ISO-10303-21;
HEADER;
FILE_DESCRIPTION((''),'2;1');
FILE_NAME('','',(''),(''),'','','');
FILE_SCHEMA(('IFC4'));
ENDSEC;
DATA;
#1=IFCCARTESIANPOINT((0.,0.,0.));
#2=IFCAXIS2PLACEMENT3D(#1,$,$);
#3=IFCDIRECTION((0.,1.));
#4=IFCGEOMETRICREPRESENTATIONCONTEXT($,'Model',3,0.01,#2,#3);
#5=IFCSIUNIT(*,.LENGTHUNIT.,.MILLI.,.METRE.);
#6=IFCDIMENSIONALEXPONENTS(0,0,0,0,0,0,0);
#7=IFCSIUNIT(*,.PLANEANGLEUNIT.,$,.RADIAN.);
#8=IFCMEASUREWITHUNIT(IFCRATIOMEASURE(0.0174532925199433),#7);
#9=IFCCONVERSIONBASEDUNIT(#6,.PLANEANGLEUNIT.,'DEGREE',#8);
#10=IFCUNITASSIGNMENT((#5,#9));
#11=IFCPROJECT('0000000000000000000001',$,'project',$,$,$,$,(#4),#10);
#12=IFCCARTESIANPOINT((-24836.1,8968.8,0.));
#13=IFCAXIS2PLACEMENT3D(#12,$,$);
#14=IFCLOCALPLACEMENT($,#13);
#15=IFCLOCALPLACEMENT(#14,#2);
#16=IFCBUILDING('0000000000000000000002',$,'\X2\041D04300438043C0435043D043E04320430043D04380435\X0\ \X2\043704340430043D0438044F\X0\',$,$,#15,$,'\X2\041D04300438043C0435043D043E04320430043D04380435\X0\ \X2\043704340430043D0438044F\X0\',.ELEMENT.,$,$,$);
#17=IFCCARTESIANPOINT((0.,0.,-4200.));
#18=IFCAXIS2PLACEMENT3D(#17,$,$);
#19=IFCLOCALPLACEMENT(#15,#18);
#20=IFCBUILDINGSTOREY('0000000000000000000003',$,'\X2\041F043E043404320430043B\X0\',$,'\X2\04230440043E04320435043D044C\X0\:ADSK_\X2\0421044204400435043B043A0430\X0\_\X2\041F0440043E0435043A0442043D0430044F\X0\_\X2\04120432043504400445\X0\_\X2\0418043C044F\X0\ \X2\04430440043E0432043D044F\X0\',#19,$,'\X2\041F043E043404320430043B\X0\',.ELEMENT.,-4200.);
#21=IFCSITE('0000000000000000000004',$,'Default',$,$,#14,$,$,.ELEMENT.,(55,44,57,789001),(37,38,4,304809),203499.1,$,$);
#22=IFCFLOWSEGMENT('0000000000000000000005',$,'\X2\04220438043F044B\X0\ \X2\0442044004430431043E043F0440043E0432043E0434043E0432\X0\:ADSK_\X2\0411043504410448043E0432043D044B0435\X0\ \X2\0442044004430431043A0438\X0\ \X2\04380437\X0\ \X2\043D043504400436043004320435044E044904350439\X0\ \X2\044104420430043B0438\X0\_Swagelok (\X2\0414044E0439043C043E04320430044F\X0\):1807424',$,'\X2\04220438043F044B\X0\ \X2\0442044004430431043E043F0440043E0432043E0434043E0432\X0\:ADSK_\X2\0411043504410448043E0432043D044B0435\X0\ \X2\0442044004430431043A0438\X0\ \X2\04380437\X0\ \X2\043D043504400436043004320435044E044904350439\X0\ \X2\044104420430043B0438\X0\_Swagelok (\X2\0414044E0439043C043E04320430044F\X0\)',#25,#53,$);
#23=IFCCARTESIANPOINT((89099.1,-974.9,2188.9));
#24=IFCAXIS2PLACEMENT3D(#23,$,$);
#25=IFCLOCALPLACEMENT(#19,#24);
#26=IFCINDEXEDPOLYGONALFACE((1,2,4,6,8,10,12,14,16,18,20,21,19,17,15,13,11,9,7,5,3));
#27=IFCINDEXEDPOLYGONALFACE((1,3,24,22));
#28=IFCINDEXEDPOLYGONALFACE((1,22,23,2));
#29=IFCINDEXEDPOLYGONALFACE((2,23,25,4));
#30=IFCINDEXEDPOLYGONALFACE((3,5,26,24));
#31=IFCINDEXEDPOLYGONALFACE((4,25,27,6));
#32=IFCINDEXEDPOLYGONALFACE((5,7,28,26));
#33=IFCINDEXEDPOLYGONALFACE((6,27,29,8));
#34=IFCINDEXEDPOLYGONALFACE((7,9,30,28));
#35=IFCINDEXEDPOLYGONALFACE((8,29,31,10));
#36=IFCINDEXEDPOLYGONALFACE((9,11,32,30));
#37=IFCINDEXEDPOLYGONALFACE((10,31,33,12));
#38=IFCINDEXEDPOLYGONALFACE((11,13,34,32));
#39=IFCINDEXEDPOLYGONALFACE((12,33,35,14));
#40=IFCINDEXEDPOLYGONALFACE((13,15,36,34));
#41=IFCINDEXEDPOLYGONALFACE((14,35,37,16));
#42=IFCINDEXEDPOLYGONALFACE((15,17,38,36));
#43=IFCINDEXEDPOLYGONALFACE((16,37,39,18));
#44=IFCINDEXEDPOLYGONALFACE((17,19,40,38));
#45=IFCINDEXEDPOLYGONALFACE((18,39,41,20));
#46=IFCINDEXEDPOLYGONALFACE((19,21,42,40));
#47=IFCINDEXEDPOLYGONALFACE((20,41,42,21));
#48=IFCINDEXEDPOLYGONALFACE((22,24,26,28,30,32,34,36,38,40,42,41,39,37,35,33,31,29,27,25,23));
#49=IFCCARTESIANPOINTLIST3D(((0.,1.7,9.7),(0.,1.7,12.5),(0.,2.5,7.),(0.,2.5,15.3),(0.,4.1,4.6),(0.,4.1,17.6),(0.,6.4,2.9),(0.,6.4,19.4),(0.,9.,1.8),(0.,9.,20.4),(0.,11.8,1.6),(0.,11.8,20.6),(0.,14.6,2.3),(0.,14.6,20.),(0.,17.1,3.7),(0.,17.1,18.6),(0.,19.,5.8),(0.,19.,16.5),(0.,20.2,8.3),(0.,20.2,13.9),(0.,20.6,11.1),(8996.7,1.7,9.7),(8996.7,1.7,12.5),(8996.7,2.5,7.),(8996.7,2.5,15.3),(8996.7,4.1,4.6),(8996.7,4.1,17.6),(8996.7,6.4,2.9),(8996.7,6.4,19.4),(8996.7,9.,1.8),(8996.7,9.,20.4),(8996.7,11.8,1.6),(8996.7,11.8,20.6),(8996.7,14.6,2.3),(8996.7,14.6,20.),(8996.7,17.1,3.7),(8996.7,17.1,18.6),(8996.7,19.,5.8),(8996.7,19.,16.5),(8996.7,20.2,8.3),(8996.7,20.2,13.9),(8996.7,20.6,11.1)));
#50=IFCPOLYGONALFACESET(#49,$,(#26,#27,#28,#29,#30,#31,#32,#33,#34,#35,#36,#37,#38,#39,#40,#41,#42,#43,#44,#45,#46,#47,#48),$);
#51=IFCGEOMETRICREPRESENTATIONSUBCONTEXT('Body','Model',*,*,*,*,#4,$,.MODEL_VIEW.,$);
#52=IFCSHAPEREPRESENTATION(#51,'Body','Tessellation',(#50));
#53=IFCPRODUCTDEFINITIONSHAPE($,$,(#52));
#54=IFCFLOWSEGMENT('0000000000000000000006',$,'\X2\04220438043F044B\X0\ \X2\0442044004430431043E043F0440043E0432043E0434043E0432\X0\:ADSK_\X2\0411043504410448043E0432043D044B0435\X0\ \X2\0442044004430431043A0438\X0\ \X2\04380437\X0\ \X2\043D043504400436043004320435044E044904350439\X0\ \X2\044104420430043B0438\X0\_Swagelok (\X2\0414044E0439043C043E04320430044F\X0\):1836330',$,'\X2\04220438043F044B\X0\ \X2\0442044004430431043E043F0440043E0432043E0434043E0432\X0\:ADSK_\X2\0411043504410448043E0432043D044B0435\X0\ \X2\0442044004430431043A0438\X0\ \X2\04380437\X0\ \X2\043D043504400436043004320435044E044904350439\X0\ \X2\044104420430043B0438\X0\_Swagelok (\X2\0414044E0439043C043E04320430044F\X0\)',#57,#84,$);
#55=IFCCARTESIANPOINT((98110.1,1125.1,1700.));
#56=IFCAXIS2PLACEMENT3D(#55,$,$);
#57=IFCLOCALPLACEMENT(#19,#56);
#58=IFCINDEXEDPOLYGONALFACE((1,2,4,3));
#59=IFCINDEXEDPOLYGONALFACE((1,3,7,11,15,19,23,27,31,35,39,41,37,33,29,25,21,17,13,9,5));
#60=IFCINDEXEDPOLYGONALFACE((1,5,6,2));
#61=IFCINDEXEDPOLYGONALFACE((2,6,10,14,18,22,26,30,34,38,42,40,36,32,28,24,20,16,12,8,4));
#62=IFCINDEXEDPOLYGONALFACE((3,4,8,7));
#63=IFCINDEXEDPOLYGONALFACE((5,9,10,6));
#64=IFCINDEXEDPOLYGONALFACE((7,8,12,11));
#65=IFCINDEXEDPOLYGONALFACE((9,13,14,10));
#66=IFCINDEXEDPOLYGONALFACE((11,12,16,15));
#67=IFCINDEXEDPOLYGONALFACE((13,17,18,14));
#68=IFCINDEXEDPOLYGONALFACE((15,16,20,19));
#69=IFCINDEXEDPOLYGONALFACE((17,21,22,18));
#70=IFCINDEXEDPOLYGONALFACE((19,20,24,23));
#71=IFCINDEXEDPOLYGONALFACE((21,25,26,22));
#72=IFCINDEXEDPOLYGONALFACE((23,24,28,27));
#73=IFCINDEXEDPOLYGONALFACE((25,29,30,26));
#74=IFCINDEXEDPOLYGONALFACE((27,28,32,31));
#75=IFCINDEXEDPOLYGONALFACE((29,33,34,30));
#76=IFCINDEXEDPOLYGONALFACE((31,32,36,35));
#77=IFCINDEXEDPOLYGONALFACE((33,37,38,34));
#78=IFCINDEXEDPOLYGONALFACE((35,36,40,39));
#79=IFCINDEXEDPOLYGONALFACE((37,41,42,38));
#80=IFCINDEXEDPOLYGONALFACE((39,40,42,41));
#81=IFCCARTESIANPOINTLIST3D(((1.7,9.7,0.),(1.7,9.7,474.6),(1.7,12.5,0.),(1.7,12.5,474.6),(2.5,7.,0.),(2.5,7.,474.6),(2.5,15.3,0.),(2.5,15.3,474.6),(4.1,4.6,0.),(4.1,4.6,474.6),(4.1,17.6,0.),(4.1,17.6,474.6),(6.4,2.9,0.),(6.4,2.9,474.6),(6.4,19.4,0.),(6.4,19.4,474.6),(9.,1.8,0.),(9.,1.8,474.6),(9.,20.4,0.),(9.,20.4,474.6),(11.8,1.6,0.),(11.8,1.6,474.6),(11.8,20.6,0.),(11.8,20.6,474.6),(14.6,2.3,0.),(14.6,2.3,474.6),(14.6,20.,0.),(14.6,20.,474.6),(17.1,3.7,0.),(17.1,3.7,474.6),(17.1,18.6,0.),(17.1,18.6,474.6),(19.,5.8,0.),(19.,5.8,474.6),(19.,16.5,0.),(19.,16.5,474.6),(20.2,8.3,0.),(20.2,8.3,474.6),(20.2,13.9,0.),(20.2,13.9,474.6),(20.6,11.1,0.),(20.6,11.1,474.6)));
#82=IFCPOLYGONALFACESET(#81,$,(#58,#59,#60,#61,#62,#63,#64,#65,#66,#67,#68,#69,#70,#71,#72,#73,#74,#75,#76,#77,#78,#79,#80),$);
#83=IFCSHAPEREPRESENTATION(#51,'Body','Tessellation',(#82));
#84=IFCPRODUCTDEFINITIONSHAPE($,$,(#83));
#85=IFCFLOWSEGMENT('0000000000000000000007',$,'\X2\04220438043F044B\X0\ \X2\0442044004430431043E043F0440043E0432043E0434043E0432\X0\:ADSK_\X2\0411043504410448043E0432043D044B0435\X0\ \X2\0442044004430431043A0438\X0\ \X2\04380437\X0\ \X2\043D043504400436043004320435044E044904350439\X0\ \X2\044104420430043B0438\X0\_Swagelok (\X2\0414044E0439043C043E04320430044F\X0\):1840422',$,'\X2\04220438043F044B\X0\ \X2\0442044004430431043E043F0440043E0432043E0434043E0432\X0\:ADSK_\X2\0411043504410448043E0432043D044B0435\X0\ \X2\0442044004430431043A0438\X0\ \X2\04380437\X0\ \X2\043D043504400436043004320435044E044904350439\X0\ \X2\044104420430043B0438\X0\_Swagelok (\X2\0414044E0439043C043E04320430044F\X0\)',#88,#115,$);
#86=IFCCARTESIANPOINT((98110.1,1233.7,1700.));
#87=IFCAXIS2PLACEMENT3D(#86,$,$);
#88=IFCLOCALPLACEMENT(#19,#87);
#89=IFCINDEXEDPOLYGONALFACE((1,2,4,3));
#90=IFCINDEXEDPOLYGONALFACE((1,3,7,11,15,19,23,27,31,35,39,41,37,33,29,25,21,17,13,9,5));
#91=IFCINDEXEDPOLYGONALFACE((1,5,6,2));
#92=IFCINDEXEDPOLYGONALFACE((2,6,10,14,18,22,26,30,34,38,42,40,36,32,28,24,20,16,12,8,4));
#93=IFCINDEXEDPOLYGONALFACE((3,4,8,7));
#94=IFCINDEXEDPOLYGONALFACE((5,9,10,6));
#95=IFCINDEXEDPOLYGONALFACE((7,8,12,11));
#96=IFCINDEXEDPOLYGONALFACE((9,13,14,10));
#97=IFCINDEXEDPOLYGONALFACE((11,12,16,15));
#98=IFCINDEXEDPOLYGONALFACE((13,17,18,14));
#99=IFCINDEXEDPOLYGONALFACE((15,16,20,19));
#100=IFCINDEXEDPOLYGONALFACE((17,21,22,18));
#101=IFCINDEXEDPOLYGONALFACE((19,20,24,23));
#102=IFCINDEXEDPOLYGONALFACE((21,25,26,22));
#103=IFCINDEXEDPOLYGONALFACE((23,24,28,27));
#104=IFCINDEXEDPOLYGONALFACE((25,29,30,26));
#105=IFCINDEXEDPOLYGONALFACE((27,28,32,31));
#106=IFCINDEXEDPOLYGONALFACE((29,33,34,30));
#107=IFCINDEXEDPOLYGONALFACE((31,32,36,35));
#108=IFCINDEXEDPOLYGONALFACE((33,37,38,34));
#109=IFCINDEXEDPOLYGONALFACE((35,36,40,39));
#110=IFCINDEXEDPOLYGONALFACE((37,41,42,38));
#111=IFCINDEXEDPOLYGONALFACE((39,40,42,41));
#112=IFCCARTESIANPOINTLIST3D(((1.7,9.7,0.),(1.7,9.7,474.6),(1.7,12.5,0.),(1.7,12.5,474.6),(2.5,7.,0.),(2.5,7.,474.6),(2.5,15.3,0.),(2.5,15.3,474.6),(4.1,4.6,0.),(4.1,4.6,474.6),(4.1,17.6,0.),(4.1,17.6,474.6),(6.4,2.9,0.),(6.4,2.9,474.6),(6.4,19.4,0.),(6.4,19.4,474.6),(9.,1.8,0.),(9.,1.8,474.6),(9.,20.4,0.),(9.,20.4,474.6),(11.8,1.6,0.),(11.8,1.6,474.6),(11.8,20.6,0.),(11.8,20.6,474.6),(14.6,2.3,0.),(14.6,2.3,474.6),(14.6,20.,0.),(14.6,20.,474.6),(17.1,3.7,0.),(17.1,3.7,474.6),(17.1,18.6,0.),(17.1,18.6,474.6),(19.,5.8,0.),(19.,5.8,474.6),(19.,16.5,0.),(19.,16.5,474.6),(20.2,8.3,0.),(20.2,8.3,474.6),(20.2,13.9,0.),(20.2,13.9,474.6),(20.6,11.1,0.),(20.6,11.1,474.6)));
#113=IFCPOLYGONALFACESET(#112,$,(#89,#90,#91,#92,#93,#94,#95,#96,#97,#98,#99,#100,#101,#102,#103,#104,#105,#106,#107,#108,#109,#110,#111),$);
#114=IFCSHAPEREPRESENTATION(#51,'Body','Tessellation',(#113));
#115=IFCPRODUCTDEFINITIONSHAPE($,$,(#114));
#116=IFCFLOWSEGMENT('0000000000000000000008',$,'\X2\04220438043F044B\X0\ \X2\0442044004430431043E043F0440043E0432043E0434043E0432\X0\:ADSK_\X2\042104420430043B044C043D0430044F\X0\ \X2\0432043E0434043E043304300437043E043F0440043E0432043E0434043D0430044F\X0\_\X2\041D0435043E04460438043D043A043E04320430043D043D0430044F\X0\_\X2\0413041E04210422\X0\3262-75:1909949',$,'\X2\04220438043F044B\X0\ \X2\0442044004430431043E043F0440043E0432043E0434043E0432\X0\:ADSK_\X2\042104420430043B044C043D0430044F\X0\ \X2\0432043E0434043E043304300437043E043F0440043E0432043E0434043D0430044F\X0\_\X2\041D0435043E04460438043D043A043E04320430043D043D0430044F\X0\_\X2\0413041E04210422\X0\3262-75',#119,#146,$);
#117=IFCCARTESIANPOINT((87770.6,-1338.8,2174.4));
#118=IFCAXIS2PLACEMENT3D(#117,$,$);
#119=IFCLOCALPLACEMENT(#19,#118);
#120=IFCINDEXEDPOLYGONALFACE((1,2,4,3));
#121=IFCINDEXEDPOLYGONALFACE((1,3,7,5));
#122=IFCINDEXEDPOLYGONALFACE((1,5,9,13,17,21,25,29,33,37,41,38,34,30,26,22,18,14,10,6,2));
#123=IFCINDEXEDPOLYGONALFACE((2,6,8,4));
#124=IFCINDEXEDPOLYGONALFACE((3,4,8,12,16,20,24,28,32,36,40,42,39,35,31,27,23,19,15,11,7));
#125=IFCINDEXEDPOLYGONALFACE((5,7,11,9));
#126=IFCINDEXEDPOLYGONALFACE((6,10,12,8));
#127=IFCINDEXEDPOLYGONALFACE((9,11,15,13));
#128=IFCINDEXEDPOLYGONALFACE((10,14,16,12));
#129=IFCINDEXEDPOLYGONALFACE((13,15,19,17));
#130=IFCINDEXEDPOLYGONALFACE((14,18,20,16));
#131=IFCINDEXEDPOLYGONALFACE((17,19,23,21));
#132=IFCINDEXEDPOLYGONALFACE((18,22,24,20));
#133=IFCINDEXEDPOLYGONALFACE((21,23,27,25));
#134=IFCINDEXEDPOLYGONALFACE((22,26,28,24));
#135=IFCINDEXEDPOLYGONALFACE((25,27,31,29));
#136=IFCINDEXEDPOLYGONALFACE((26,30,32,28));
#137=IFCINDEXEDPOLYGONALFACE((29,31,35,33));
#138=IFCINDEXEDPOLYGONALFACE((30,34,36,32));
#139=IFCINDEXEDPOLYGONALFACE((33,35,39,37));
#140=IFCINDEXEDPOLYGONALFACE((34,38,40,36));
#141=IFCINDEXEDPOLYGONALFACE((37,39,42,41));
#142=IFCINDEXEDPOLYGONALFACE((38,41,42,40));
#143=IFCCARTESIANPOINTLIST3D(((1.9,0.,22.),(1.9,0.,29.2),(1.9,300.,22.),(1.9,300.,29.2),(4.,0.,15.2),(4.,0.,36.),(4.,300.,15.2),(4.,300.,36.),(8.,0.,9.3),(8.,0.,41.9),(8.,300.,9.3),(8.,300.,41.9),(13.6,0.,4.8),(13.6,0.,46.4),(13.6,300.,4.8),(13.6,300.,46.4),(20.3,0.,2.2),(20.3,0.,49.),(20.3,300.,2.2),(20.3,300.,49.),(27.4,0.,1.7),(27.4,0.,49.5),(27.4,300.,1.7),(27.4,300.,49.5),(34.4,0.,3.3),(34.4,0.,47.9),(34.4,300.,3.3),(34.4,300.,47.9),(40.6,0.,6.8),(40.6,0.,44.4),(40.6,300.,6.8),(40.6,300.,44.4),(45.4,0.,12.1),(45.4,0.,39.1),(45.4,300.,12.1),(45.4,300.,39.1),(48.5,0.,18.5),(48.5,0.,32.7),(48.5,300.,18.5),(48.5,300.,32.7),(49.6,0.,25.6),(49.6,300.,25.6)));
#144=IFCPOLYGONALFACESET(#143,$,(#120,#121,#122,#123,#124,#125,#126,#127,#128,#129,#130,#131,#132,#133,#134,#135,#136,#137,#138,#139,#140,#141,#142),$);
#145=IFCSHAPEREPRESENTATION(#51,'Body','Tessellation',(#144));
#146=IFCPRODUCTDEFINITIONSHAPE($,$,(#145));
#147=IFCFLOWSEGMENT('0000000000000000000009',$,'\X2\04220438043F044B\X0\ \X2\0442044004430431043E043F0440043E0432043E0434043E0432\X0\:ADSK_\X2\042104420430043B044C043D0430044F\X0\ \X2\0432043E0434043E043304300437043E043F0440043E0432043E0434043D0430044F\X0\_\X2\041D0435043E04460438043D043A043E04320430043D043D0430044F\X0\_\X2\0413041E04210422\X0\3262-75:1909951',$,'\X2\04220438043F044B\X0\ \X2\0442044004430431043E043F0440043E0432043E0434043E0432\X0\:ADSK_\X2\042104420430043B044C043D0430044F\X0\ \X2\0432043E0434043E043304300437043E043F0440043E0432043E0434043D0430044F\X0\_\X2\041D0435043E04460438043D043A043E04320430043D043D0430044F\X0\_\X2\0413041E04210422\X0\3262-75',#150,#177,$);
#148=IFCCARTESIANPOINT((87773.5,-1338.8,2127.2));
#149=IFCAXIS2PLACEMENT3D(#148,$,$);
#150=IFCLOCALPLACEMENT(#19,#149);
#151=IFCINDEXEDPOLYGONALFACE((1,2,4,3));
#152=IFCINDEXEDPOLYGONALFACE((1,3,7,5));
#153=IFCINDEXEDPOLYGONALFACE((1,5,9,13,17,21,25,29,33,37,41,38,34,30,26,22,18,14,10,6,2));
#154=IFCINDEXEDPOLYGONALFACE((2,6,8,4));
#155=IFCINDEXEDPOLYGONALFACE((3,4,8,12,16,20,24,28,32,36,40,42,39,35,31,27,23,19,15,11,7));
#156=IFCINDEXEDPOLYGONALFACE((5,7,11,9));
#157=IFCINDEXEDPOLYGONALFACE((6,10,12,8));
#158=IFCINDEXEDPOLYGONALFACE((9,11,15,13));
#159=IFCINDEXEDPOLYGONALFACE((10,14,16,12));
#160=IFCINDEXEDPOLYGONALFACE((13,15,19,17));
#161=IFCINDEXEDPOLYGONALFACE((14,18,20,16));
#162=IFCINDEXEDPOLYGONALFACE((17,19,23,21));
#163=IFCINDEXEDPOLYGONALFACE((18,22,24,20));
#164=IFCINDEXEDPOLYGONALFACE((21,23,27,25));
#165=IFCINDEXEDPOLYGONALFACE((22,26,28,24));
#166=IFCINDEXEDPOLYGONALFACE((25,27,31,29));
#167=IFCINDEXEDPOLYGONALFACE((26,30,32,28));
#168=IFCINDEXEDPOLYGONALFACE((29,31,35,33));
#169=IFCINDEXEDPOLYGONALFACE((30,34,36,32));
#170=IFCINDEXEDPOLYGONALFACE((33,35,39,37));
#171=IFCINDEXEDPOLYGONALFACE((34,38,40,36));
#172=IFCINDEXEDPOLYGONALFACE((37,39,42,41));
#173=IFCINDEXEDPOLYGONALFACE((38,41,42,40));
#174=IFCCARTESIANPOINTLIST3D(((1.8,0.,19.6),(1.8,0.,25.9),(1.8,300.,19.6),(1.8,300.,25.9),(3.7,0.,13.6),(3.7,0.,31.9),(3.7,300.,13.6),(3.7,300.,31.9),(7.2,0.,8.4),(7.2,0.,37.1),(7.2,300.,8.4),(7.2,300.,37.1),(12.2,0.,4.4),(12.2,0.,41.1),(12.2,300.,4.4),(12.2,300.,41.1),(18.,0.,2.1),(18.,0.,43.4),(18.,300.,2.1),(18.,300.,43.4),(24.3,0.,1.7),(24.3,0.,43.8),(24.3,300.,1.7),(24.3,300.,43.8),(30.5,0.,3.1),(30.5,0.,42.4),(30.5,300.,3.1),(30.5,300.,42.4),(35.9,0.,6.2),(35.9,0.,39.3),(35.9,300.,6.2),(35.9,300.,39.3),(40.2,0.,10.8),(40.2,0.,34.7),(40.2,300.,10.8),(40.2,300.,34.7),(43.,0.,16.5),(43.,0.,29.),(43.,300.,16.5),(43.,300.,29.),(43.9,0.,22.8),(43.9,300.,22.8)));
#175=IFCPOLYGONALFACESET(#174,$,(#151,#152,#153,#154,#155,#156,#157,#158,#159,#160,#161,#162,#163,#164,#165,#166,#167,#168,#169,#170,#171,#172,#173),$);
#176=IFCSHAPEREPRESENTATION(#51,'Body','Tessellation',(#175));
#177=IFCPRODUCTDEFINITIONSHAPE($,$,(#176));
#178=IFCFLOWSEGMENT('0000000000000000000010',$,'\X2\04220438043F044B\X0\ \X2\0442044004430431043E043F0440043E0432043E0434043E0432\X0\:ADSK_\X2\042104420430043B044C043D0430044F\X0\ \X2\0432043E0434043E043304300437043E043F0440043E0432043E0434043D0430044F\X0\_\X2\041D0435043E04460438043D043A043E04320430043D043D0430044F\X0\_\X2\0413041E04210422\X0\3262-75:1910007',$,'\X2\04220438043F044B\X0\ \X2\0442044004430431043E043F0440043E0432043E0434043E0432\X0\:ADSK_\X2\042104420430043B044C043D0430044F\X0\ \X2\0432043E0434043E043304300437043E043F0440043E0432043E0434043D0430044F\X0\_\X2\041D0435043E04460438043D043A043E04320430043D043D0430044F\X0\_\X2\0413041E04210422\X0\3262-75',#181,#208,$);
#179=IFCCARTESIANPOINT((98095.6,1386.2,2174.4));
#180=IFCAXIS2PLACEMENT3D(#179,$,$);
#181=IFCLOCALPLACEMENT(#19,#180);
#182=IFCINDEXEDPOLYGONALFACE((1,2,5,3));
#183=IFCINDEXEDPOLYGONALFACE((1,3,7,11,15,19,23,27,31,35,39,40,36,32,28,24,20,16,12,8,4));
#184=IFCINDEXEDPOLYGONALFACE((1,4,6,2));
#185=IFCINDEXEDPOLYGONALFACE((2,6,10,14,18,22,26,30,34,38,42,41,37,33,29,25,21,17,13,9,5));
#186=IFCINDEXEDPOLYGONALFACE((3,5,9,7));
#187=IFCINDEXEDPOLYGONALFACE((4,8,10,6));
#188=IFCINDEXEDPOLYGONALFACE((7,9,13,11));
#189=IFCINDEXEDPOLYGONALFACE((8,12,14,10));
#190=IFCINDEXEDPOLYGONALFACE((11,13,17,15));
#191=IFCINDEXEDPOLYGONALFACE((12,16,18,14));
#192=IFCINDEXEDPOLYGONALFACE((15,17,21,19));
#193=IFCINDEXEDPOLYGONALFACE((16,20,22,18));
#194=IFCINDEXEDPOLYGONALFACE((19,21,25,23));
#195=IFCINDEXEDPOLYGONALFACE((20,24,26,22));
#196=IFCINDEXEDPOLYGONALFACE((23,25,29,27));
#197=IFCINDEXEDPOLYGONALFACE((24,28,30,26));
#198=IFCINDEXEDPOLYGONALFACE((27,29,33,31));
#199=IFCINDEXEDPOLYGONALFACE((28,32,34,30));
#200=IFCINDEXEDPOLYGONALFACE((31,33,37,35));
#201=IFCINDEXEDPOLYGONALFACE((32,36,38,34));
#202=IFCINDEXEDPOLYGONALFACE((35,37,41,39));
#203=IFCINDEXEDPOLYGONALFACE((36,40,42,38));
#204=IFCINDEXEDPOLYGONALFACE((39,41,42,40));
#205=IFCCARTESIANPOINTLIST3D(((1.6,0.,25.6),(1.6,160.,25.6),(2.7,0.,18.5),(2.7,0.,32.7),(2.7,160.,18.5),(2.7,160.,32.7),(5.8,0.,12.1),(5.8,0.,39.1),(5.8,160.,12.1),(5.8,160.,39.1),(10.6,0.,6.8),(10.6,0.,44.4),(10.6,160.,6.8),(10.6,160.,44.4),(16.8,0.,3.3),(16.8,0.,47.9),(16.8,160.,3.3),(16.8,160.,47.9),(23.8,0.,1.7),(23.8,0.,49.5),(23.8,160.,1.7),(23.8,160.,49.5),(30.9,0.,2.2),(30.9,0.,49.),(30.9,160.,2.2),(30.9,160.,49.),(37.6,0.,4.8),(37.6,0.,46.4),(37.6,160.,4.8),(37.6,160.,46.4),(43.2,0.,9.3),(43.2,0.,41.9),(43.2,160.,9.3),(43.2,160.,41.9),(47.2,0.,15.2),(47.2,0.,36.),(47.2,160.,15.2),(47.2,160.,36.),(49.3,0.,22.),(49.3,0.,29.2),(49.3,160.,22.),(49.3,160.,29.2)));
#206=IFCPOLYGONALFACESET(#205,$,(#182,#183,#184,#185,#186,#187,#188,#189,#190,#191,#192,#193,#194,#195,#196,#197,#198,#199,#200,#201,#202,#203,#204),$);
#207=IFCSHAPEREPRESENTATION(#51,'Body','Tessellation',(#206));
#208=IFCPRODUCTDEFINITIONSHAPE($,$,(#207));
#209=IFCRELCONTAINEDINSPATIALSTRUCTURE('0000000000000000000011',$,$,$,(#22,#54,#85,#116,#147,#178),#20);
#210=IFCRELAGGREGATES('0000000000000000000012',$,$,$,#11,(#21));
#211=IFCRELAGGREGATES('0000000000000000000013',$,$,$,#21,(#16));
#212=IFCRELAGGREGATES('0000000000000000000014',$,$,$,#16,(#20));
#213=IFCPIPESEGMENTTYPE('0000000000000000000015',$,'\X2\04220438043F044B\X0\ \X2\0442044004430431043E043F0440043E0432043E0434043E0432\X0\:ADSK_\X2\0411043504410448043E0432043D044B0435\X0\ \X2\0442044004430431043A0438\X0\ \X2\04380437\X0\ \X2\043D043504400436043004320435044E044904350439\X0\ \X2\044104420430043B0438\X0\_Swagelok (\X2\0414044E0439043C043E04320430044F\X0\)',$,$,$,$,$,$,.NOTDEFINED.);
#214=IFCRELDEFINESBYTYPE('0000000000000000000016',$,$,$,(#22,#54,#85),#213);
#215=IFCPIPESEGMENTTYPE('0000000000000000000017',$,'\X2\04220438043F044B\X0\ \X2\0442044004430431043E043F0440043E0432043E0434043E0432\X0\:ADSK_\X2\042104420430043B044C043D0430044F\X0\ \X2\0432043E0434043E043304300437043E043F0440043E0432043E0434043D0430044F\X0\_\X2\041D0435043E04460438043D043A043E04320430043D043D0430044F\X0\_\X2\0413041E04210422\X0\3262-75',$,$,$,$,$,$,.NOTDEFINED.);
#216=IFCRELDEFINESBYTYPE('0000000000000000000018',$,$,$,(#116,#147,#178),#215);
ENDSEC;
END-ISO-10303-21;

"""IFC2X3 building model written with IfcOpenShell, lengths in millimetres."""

from ifc_helpers import new_model, entity, si_unit, converted_unit, direction, frame, origin, origin_2d_with_axis, place, context, subcontext, project, spatial, circle, extrude, type_object, element, save


model = new_model("IFC2X3")

# Units and contexts
model_context = context("Model", 3, precision=0.01, world=origin(), true_north=direction((0.0, 1.0)))
body_context = subcontext(model_context, "Body", "Model", "MODEL_VIEW")
ifc_project = project(units=[si_unit("LENGTHUNIT", "METRE", prefix="MILLI"), converted_unit("PLANEANGLEUNIT", "DEGREE", entity("IfcRatioMeasure", 0.0174532925199433), si_unit("PLANEANGLEUNIT", "RADIAN"), dimensions=[0, 0, 0, 0, 0, 0, 0])], contexts=[model_context])

# Site, building, storey
site_placement = place(None, frame((-24836.1, 8968.8, 0.0)))
site = spatial("IfcSite", under=ifc_project, at=site_placement, Name="Default", CompositionType="ELEMENT", RefLatitude=(55, 44, 57, 789001), RefLongitude=(37, 38, 4, 304809), RefElevation=203499.1)
building_placement = place(site_placement, origin())
building = spatial("IfcBuilding", under=site, at=building_placement, Name="Наименование здания", LongName="Наименование здания", CompositionType="ELEMENT")
storey_placement = place(building_placement, frame((0.0, 0.0, -4200.0)))
storey = spatial("IfcBuildingStorey", under=building, at=storey_placement, Name="Подвал", ObjectType="Уровень:ADSK_Стрелка_Проектная_Вверх_Имя уровня", LongName="Подвал", CompositionType="ELEMENT", Elevation=-4200.0)

# Flow segments
pipe_segment_type_1 = type_object("IfcPipeSegmentType", Name="Типы трубопроводов:ADSK_Бесшовные трубки из нержавеющей стали_Swagelok (Дюймовая)", PredefinedType="NOTDEFINED")
flow_segment_1_placement = place(storey_placement, frame((89099.1, -974.9, 2188.9)))
element("IfcFlowSegment", 1, at=flow_segment_1_placement, inside=storey, type_object=pipe_segment_type_1, Name="Типы трубопроводов:ADSK_Бесшовные трубки из нержавеющей стали_Swagelok (Дюймовая):1807424", ObjectType="Типы трубопроводов:ADSK_Бесшовные трубки из нержавеющей стали_Swagelok (Дюймовая)", context=body_context, shape_type="SweptSolid", body=[
    extrude(circle(Radius=9.5, at=origin_2d_with_axis()), frame((0.0, 11.1, 11.1), z_axis=(1.0, 0.0, 0.0), x_axis=(0.0, 1.0, 0.0)), (0.0, 0.0, 1.0), 8996.7),
])
flow_segment_2_placement = place(storey_placement, frame((98110.1, 1125.1, 1700.0)))
element("IfcFlowSegment", 2, at=flow_segment_2_placement, inside=storey, type_object=pipe_segment_type_1, Name="Типы трубопроводов:ADSK_Бесшовные трубки из нержавеющей стали_Swagelok (Дюймовая):1836330", ObjectType="Типы трубопроводов:ADSK_Бесшовные трубки из нержавеющей стали_Swagelok (Дюймовая)", context=body_context, shape_type="SweptSolid", body=[
    extrude(circle(Radius=9.5, at=origin_2d_with_axis()), frame((11.1, 11.1, 0.0)), (0.0, 0.0, 1.0), 474.6),
])
flow_segment_3_placement = place(storey_placement, frame((98110.1, 1233.7, 1700.0)))
element("IfcFlowSegment", 3, at=flow_segment_3_placement, inside=storey, type_object=pipe_segment_type_1, Name="Типы трубопроводов:ADSK_Бесшовные трубки из нержавеющей стали_Swagelok (Дюймовая):1840422", ObjectType="Типы трубопроводов:ADSK_Бесшовные трубки из нержавеющей стали_Swagelok (Дюймовая)", context=body_context, shape_type="SweptSolid", body=[
    extrude(circle(Radius=9.5, at=origin_2d_with_axis()), frame((11.1, 11.1, 0.0)), (0.0, 0.0, 1.0), 474.6),
])
pipe_segment_type_2 = type_object("IfcPipeSegmentType", Name="Типы трубопроводов:ADSK_Стальная водогазопроводная_Неоцинкованная_ГОСТ3262-75", PredefinedType="NOTDEFINED")
flow_segment_4_placement = place(storey_placement, frame((87770.6, -1338.8, 2174.4)))
element("IfcFlowSegment", 4, at=flow_segment_4_placement, inside=storey, type_object=pipe_segment_type_2, Name="Типы трубопроводов:ADSK_Стальная водогазопроводная_Неоцинкованная_ГОСТ3262-75:1909949", ObjectType="Типы трубопроводов:ADSK_Стальная водогазопроводная_Неоцинкованная_ГОСТ3262-75", context=body_context, shape_type="SweptSolid", body=[
    extrude(circle(Radius=24.0, at=origin_2d_with_axis()), frame((25.6, 0.0, 25.6), z_axis=(0.0, 1.0, 0.0), x_axis=(1.0, 0.0, 0.0)), (0.0, 0.0, 1.0), 300.0),
])
flow_segment_5_placement = place(storey_placement, frame((87773.5, -1338.8, 2127.2)))
element("IfcFlowSegment", 5, at=flow_segment_5_placement, inside=storey, type_object=pipe_segment_type_2, Name="Типы трубопроводов:ADSK_Стальная водогазопроводная_Неоцинкованная_ГОСТ3262-75:1909951", ObjectType="Типы трубопроводов:ADSK_Стальная водогазопроводная_Неоцинкованная_ГОСТ3262-75", context=body_context, shape_type="SweptSolid", body=[
    extrude(circle(Radius=21.1, at=origin_2d_with_axis()), frame((22.8, 0.0, 22.8), z_axis=(0.0, 1.0, 0.0), x_axis=(1.0, 0.0, 0.0)), (0.0, 0.0, 1.0), 300.0),
])
flow_segment_6_placement = place(storey_placement, frame((98095.6, 1386.2, 2174.4)))
element("IfcFlowSegment", 6, at=flow_segment_6_placement, inside=storey, type_object=pipe_segment_type_2, Name="Типы трубопроводов:ADSK_Стальная водогазопроводная_Неоцинкованная_ГОСТ3262-75:1910007", ObjectType="Типы трубопроводов:ADSK_Стальная водогазопроводная_Неоцинкованная_ГОСТ3262-75", context=body_context, shape_type="SweptSolid", body=[
    extrude(circle(Radius=24.0, at=origin_2d_with_axis()), frame((25.6, 0.0, 25.6), z_axis=(0.0, 1.0, 0.0), x_axis=(-1.0, 0.0, 0.0)), (0.0, 0.0, 1.0), 160.0),
])

save(model, "model.ifc")
